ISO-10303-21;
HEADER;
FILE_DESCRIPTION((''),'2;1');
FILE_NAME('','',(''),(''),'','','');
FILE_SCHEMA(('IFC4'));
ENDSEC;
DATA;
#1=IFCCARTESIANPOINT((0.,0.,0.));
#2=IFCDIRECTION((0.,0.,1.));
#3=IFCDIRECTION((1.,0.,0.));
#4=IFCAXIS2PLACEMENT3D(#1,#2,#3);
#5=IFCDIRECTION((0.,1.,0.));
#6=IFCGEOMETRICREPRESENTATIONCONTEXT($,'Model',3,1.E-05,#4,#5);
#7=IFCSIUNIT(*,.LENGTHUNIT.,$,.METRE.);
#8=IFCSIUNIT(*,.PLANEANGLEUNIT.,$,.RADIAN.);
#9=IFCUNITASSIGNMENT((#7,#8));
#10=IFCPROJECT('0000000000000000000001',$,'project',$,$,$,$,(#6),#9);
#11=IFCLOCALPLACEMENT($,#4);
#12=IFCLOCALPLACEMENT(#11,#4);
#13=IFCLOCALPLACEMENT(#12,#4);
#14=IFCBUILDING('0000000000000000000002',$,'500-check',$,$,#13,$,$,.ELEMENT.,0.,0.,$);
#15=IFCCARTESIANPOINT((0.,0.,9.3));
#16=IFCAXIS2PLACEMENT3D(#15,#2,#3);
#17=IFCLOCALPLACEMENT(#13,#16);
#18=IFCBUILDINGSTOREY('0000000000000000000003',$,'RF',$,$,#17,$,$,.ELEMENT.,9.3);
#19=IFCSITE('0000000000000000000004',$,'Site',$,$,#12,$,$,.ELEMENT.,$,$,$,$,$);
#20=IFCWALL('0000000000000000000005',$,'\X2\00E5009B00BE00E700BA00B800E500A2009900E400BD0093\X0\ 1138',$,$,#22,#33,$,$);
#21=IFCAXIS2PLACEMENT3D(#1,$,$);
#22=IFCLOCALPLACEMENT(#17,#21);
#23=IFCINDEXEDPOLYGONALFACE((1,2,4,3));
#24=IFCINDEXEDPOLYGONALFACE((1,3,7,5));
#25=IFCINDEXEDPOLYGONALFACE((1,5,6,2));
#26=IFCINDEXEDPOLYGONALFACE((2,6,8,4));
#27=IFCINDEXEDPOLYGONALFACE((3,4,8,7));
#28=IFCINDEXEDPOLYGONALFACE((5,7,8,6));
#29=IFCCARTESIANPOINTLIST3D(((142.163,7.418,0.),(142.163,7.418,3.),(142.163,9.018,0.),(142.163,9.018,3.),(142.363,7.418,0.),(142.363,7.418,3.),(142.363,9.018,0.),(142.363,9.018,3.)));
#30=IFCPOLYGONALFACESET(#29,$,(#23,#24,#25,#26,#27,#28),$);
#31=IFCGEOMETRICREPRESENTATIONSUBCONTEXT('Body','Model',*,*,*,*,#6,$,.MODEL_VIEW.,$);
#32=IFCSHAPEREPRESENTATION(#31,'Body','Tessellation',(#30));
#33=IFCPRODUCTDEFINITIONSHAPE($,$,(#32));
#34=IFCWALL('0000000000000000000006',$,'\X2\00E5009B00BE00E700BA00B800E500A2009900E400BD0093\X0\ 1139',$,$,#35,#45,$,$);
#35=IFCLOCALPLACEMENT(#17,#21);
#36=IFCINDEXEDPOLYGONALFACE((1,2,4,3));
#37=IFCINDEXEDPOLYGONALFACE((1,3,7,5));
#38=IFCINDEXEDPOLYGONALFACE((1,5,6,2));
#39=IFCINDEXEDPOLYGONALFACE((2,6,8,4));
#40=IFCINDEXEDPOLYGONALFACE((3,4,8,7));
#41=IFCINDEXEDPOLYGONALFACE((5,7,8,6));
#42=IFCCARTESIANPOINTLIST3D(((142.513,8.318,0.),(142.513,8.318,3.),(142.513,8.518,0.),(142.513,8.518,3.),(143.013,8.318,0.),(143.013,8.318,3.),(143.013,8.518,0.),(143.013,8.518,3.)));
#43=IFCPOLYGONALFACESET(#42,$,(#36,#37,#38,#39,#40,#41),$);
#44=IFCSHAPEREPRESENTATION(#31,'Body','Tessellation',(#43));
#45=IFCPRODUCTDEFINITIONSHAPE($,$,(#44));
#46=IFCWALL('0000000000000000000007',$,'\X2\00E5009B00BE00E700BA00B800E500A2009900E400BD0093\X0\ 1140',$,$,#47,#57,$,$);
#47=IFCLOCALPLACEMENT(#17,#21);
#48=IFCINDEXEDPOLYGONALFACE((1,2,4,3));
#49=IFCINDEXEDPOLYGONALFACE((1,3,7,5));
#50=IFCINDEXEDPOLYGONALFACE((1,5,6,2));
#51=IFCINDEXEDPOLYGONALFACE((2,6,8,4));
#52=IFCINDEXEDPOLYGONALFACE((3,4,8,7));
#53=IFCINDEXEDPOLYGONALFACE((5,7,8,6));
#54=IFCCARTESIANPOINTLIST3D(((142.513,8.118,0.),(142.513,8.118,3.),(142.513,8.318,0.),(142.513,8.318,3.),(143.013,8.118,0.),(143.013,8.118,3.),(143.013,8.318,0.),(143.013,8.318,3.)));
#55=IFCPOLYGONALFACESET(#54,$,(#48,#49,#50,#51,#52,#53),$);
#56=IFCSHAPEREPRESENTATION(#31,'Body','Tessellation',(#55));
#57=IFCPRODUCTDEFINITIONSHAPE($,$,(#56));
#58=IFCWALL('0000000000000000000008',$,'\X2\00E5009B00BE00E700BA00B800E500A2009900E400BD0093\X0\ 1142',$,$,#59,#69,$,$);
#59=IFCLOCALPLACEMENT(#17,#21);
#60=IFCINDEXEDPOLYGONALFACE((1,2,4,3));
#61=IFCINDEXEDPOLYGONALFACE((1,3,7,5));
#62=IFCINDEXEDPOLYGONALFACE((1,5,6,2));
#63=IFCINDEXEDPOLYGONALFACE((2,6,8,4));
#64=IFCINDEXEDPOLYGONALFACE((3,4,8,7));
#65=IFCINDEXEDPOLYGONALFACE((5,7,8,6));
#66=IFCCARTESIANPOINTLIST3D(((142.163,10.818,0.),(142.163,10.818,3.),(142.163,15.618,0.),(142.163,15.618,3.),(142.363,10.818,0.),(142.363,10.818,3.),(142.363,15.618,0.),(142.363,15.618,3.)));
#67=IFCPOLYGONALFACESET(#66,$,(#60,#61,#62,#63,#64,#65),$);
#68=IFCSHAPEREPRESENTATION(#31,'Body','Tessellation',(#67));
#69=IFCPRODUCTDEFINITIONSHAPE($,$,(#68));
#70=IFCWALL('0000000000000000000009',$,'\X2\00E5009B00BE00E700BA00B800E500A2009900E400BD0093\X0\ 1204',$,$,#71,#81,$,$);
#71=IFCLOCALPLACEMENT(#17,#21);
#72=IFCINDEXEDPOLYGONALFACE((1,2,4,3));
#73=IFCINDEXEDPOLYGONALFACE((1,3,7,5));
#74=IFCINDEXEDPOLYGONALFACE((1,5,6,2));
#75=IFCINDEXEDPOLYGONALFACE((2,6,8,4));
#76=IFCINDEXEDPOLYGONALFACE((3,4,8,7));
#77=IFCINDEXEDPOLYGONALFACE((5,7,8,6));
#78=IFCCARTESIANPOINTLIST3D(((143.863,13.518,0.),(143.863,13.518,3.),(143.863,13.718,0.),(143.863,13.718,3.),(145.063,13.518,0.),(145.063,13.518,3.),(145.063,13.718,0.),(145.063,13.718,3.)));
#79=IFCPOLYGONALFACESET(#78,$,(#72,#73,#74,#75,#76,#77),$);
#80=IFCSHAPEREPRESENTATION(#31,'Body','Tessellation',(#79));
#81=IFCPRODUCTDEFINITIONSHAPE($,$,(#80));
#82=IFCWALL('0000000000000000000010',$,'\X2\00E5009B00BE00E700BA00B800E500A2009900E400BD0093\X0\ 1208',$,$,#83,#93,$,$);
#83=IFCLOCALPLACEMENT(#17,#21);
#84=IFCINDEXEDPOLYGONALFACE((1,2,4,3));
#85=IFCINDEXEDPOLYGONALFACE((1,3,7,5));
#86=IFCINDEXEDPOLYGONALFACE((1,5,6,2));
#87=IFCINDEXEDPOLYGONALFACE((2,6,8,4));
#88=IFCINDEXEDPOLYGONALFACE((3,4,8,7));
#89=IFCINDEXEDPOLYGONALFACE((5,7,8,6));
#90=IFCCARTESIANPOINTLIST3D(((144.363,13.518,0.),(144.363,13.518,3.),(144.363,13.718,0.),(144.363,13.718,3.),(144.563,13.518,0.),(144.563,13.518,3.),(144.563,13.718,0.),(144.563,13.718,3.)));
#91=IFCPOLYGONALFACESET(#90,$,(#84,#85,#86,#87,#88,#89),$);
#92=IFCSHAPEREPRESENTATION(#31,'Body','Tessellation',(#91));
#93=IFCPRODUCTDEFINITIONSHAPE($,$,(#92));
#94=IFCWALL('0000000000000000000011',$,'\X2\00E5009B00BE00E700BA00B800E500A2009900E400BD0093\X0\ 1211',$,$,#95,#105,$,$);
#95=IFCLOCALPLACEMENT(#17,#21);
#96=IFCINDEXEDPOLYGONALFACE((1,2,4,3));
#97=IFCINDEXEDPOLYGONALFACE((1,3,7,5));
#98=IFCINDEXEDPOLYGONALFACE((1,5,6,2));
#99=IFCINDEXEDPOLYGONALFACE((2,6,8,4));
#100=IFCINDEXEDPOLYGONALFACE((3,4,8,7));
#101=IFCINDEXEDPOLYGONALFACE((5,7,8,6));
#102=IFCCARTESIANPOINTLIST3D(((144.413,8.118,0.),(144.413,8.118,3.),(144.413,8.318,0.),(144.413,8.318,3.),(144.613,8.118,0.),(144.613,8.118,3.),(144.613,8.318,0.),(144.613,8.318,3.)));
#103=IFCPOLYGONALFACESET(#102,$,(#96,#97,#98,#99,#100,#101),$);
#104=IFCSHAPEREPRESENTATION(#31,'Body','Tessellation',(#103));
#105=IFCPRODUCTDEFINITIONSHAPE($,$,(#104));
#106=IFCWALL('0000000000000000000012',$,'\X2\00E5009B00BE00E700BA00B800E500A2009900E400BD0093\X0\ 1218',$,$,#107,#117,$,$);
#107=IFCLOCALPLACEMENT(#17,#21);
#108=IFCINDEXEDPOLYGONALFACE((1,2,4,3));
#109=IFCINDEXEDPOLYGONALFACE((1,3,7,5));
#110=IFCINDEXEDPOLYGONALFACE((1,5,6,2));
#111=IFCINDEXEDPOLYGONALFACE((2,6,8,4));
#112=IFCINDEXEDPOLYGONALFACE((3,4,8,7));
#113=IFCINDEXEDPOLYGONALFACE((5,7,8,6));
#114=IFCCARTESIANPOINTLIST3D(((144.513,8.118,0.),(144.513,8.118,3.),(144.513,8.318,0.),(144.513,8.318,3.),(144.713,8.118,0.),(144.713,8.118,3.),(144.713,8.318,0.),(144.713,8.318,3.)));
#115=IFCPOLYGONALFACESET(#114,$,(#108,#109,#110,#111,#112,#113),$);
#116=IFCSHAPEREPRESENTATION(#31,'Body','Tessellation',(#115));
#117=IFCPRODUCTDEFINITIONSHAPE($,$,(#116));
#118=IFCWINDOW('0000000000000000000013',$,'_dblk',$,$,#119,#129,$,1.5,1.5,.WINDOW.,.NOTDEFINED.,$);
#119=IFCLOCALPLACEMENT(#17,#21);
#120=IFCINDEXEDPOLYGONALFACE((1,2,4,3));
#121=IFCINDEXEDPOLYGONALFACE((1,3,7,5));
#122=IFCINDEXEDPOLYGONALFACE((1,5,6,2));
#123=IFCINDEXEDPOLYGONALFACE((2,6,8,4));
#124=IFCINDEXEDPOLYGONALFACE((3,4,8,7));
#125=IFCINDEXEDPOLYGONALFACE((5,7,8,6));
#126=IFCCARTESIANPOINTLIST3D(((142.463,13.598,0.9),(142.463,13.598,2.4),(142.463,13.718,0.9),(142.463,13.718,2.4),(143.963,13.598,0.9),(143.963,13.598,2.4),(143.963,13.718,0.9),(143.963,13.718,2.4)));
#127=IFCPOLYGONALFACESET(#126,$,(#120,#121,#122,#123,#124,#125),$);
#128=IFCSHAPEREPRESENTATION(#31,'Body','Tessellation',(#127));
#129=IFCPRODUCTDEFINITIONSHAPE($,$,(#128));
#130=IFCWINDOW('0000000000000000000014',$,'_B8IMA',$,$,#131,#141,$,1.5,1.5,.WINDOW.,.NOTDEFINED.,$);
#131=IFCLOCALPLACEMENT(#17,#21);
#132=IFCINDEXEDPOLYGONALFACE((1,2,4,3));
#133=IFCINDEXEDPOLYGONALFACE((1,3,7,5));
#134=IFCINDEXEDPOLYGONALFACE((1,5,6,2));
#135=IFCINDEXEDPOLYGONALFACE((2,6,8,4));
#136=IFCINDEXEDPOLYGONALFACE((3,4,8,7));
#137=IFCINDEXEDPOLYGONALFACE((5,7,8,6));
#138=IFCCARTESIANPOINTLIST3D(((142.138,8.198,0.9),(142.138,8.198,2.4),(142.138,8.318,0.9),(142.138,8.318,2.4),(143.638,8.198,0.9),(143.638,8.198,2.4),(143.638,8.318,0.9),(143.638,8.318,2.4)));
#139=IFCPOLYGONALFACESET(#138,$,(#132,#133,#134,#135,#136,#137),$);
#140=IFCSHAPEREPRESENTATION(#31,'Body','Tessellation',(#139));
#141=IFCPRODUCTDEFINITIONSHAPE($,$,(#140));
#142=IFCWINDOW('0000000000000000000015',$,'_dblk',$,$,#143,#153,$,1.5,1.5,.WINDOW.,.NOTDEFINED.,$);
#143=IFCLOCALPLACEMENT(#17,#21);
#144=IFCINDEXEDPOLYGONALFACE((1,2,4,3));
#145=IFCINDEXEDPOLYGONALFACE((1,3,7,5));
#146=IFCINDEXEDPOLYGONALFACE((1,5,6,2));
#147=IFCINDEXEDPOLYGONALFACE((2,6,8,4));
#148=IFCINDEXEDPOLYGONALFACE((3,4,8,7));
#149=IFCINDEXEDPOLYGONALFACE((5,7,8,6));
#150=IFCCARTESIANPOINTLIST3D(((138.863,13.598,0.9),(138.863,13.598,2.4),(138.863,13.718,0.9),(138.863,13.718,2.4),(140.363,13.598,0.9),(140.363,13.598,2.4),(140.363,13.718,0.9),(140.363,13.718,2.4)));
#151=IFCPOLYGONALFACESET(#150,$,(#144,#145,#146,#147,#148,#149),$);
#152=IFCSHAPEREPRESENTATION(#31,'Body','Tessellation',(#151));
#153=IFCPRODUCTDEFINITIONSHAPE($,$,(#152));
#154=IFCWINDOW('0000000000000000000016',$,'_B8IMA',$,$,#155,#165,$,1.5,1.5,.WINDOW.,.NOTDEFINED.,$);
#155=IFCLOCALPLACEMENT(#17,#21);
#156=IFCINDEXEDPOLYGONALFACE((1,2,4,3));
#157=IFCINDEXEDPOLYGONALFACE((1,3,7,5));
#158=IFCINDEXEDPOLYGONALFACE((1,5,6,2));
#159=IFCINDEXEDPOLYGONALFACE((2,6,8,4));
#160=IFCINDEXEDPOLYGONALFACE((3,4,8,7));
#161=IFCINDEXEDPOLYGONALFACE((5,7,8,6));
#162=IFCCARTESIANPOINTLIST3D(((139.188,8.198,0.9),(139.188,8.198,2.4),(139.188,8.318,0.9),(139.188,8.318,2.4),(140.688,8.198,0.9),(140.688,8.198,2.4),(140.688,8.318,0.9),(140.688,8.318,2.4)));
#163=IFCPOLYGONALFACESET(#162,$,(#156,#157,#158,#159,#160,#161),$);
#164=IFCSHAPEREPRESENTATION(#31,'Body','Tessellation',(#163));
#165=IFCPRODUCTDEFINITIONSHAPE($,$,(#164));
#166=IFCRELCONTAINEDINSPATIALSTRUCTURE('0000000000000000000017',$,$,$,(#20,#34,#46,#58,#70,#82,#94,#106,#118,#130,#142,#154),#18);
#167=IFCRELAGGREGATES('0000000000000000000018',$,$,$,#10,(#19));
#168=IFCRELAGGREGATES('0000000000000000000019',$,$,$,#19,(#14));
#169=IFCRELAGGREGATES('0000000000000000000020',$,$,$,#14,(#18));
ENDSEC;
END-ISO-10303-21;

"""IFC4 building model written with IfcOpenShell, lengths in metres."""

from ifc_helpers import new_model, si_unit, direction, frame, frame_2d, origin_with_axes, place, context, subcontext, project, spatial, rectangle, extrude, element, save


model = new_model("IFC4")

# Units and contexts
model_context = context("Model", 3, precision=1e-05, world=origin_with_axes(), true_north=direction((0.0, 1.0, 0.0)))
body_context = subcontext(model_context, "Body", "Model", "MODEL_VIEW")
ifc_project = project(units=[si_unit("LENGTHUNIT", "METRE"), si_unit("PLANEANGLEUNIT", "RADIAN")], contexts=[model_context])

# Site, building, storey
placement = place(None, origin_with_axes())
site_placement = place(placement, origin_with_axes())
site = spatial("IfcSite", under=ifc_project, at=site_placement, Name="Site", CompositionType="ELEMENT")
building_placement = place(site_placement, origin_with_axes())
building = spatial("IfcBuilding", under=site, at=building_placement, Name="500-check", CompositionType="ELEMENT", ElevationOfRefHeight=0.0, ElevationOfTerrain=0.0)
storey_placement = place(building_placement, frame((0.0, 0.0, 9.3), z_axis=(0.0, 0.0, 1.0), x_axis=(1.0, 0.0, 0.0)))
storey = spatial("IfcBuildingStorey", under=building, at=storey_placement, Name="RF", CompositionType="ELEMENT", Elevation=9.3)

# Walls
wall_1_placement = place(storey_placement, frame((142.263, 8.218, 0.0), z_axis=(0.0, 0.0, 1.0), x_axis=(0.0, -1.0, 0.0)))
element("IfcWall", 1, at=wall_1_placement, inside=storey, Name="å\u009b¾çº¸å¢\u0099ä½\u0093 1138", context=body_context, shape_type="SweptSolid", body=[
    extrude(rectangle(XDim=1.6, YDim=0.2, at=frame_2d((0.0, 0.0), x_axis=(1.0, 0.0, 0.0))), frame((0.0, 0.0, 0.0), z_axis=(0.0, 0.0, 1.0)), (0.0, 0.0, 1.0), 3.0),
])
for number, where, z_axis, x_axis, name in (
    (2, (142.763, 8.418, 0.0), (0.0, 0.0, 1.0), (-1.0, 0.0, 0.0), "å\u009b¾çº¸å¢\u0099ä½\u0093 1139"),
    (3, (142.763, 8.218, 0.0), (0.0, 0.0, 1.0), (-1.0, 0.0, 0.0), "å\u009b¾çº¸å¢\u0099ä½\u0093 1140"),
):
    element("IfcWall", number, at=place(storey_placement, frame(where, z_axis=z_axis, x_axis=x_axis)), inside=storey, Name=name, context=body_context, shape_type="SweptSolid", body=[
        extrude(rectangle(XDim=0.5, YDim=0.2, at=frame_2d((0.0, 0.0), x_axis=(1.0, 0.0, 0.0))), frame((0.0, 0.0, 0.0), z_axis=(0.0, 0.0, 1.0)), (0.0, 0.0, 1.0), 3.0),
    ])
wall_2_placement = place(storey_placement, frame((142.263, 13.218, 0.0), z_axis=(0.0, 0.0, 1.0), x_axis=(0.0, -1.0, 0.0)))
element("IfcWall", 4, at=wall_2_placement, inside=storey, Name="å\u009b¾çº¸å¢\u0099ä½\u0093 1142", context=body_context, shape_type="SweptSolid", body=[
    extrude(rectangle(XDim=4.8, YDim=0.2, at=frame_2d((0.0, 0.0), x_axis=(1.0, 0.0, 0.0))), frame((0.0, 0.0, 0.0), z_axis=(0.0, 0.0, 1.0)), (0.0, 0.0, 1.0), 3.0),
])
wall_3_placement = place(storey_placement, frame((144.463, 13.618, 0.0), z_axis=(0.0, 0.0, 1.0), x_axis=(1.0, 0.0, 0.0)))
element("IfcWall", 5, at=wall_3_placement, inside=storey, Name="å\u009b¾çº¸å¢\u0099ä½\u0093 1204", context=body_context, shape_type="SweptSolid", body=[
    extrude(rectangle(XDim=1.2, YDim=0.2, at=frame_2d((0.0, 0.0), x_axis=(1.0, 0.0, 0.0))), frame((0.0, 0.0, 0.0), z_axis=(0.0, 0.0, 1.0)), (0.0, 0.0, 1.0), 3.0),
])
for number, where, z_axis, x_axis, name in (
    (6, (144.463, 13.618, 0.0), (0.0, 0.0, 1.0), (0.0, 1.0, 0.0), "å\u009b¾çº¸å¢\u0099ä½\u0093 1208"),
    (7, (144.513, 8.218, 0.0), (0.0, 0.0, 1.0), (0.0, 1.0, 0.0), "å\u009b¾çº¸å¢\u0099ä½\u0093 1211"),
    (8, (144.613, 8.218, 0.0), (0.0, 0.0, 1.0), (0.0, -1.0, 0.0), "å\u009b¾çº¸å¢\u0099ä½\u0093 1218"),
):
    element("IfcWall", number, at=place(storey_placement, frame(where, z_axis=z_axis, x_axis=x_axis)), inside=storey, Name=name, context=body_context, shape_type="SweptSolid", body=[
        extrude(rectangle(XDim=0.2, YDim=0.2, at=frame_2d((0.0, 0.0), x_axis=(1.0, 0.0, 0.0))), frame((0.0, 0.0, 0.0), z_axis=(0.0, 0.0, 1.0)), (0.0, 0.0, 1.0), 3.0),
    ])

# Windows
for number, where, z_axis, x_axis, name in (
    (9, (143.213, 13.658, 0.9), (0.0, 0.0, 1.0), (1.0, 0.0, 0.0), "_dblk"),
    (10, (142.888, 8.258, 0.9), (0.0, 0.0, 1.0), (1.0, 0.0, 0.0), "_B8IMA"),
    (11, (139.613, 13.658, 0.9), (0.0, 0.0, 1.0), (1.0, 0.0, 0.0), "_dblk"),
    (12, (139.938, 8.258, 0.9), (0.0, 0.0, 1.0), (1.0, 0.0, 0.0), "_B8IMA"),
):
    element("IfcWindow", number, at=place(storey_placement, frame(where, z_axis=z_axis, x_axis=x_axis)), inside=storey, Name=name, OverallHeight=1.5, OverallWidth=1.5, PartitioningType="NOTDEFINED", PredefinedType="WINDOW", context=body_context, shape_type="SweptSolid", body=[
        extrude(rectangle(XDim=1.5, YDim=0.12, at=frame_2d((0.0, 0.0), x_axis=(1.0, 0.0, 0.0))), frame((0.0, 0.0, 0.0), z_axis=(0.0, 0.0, 1.0)), (0.0, 0.0, 1.0), 1.5),
    ])

save(model, "model.ifc")
